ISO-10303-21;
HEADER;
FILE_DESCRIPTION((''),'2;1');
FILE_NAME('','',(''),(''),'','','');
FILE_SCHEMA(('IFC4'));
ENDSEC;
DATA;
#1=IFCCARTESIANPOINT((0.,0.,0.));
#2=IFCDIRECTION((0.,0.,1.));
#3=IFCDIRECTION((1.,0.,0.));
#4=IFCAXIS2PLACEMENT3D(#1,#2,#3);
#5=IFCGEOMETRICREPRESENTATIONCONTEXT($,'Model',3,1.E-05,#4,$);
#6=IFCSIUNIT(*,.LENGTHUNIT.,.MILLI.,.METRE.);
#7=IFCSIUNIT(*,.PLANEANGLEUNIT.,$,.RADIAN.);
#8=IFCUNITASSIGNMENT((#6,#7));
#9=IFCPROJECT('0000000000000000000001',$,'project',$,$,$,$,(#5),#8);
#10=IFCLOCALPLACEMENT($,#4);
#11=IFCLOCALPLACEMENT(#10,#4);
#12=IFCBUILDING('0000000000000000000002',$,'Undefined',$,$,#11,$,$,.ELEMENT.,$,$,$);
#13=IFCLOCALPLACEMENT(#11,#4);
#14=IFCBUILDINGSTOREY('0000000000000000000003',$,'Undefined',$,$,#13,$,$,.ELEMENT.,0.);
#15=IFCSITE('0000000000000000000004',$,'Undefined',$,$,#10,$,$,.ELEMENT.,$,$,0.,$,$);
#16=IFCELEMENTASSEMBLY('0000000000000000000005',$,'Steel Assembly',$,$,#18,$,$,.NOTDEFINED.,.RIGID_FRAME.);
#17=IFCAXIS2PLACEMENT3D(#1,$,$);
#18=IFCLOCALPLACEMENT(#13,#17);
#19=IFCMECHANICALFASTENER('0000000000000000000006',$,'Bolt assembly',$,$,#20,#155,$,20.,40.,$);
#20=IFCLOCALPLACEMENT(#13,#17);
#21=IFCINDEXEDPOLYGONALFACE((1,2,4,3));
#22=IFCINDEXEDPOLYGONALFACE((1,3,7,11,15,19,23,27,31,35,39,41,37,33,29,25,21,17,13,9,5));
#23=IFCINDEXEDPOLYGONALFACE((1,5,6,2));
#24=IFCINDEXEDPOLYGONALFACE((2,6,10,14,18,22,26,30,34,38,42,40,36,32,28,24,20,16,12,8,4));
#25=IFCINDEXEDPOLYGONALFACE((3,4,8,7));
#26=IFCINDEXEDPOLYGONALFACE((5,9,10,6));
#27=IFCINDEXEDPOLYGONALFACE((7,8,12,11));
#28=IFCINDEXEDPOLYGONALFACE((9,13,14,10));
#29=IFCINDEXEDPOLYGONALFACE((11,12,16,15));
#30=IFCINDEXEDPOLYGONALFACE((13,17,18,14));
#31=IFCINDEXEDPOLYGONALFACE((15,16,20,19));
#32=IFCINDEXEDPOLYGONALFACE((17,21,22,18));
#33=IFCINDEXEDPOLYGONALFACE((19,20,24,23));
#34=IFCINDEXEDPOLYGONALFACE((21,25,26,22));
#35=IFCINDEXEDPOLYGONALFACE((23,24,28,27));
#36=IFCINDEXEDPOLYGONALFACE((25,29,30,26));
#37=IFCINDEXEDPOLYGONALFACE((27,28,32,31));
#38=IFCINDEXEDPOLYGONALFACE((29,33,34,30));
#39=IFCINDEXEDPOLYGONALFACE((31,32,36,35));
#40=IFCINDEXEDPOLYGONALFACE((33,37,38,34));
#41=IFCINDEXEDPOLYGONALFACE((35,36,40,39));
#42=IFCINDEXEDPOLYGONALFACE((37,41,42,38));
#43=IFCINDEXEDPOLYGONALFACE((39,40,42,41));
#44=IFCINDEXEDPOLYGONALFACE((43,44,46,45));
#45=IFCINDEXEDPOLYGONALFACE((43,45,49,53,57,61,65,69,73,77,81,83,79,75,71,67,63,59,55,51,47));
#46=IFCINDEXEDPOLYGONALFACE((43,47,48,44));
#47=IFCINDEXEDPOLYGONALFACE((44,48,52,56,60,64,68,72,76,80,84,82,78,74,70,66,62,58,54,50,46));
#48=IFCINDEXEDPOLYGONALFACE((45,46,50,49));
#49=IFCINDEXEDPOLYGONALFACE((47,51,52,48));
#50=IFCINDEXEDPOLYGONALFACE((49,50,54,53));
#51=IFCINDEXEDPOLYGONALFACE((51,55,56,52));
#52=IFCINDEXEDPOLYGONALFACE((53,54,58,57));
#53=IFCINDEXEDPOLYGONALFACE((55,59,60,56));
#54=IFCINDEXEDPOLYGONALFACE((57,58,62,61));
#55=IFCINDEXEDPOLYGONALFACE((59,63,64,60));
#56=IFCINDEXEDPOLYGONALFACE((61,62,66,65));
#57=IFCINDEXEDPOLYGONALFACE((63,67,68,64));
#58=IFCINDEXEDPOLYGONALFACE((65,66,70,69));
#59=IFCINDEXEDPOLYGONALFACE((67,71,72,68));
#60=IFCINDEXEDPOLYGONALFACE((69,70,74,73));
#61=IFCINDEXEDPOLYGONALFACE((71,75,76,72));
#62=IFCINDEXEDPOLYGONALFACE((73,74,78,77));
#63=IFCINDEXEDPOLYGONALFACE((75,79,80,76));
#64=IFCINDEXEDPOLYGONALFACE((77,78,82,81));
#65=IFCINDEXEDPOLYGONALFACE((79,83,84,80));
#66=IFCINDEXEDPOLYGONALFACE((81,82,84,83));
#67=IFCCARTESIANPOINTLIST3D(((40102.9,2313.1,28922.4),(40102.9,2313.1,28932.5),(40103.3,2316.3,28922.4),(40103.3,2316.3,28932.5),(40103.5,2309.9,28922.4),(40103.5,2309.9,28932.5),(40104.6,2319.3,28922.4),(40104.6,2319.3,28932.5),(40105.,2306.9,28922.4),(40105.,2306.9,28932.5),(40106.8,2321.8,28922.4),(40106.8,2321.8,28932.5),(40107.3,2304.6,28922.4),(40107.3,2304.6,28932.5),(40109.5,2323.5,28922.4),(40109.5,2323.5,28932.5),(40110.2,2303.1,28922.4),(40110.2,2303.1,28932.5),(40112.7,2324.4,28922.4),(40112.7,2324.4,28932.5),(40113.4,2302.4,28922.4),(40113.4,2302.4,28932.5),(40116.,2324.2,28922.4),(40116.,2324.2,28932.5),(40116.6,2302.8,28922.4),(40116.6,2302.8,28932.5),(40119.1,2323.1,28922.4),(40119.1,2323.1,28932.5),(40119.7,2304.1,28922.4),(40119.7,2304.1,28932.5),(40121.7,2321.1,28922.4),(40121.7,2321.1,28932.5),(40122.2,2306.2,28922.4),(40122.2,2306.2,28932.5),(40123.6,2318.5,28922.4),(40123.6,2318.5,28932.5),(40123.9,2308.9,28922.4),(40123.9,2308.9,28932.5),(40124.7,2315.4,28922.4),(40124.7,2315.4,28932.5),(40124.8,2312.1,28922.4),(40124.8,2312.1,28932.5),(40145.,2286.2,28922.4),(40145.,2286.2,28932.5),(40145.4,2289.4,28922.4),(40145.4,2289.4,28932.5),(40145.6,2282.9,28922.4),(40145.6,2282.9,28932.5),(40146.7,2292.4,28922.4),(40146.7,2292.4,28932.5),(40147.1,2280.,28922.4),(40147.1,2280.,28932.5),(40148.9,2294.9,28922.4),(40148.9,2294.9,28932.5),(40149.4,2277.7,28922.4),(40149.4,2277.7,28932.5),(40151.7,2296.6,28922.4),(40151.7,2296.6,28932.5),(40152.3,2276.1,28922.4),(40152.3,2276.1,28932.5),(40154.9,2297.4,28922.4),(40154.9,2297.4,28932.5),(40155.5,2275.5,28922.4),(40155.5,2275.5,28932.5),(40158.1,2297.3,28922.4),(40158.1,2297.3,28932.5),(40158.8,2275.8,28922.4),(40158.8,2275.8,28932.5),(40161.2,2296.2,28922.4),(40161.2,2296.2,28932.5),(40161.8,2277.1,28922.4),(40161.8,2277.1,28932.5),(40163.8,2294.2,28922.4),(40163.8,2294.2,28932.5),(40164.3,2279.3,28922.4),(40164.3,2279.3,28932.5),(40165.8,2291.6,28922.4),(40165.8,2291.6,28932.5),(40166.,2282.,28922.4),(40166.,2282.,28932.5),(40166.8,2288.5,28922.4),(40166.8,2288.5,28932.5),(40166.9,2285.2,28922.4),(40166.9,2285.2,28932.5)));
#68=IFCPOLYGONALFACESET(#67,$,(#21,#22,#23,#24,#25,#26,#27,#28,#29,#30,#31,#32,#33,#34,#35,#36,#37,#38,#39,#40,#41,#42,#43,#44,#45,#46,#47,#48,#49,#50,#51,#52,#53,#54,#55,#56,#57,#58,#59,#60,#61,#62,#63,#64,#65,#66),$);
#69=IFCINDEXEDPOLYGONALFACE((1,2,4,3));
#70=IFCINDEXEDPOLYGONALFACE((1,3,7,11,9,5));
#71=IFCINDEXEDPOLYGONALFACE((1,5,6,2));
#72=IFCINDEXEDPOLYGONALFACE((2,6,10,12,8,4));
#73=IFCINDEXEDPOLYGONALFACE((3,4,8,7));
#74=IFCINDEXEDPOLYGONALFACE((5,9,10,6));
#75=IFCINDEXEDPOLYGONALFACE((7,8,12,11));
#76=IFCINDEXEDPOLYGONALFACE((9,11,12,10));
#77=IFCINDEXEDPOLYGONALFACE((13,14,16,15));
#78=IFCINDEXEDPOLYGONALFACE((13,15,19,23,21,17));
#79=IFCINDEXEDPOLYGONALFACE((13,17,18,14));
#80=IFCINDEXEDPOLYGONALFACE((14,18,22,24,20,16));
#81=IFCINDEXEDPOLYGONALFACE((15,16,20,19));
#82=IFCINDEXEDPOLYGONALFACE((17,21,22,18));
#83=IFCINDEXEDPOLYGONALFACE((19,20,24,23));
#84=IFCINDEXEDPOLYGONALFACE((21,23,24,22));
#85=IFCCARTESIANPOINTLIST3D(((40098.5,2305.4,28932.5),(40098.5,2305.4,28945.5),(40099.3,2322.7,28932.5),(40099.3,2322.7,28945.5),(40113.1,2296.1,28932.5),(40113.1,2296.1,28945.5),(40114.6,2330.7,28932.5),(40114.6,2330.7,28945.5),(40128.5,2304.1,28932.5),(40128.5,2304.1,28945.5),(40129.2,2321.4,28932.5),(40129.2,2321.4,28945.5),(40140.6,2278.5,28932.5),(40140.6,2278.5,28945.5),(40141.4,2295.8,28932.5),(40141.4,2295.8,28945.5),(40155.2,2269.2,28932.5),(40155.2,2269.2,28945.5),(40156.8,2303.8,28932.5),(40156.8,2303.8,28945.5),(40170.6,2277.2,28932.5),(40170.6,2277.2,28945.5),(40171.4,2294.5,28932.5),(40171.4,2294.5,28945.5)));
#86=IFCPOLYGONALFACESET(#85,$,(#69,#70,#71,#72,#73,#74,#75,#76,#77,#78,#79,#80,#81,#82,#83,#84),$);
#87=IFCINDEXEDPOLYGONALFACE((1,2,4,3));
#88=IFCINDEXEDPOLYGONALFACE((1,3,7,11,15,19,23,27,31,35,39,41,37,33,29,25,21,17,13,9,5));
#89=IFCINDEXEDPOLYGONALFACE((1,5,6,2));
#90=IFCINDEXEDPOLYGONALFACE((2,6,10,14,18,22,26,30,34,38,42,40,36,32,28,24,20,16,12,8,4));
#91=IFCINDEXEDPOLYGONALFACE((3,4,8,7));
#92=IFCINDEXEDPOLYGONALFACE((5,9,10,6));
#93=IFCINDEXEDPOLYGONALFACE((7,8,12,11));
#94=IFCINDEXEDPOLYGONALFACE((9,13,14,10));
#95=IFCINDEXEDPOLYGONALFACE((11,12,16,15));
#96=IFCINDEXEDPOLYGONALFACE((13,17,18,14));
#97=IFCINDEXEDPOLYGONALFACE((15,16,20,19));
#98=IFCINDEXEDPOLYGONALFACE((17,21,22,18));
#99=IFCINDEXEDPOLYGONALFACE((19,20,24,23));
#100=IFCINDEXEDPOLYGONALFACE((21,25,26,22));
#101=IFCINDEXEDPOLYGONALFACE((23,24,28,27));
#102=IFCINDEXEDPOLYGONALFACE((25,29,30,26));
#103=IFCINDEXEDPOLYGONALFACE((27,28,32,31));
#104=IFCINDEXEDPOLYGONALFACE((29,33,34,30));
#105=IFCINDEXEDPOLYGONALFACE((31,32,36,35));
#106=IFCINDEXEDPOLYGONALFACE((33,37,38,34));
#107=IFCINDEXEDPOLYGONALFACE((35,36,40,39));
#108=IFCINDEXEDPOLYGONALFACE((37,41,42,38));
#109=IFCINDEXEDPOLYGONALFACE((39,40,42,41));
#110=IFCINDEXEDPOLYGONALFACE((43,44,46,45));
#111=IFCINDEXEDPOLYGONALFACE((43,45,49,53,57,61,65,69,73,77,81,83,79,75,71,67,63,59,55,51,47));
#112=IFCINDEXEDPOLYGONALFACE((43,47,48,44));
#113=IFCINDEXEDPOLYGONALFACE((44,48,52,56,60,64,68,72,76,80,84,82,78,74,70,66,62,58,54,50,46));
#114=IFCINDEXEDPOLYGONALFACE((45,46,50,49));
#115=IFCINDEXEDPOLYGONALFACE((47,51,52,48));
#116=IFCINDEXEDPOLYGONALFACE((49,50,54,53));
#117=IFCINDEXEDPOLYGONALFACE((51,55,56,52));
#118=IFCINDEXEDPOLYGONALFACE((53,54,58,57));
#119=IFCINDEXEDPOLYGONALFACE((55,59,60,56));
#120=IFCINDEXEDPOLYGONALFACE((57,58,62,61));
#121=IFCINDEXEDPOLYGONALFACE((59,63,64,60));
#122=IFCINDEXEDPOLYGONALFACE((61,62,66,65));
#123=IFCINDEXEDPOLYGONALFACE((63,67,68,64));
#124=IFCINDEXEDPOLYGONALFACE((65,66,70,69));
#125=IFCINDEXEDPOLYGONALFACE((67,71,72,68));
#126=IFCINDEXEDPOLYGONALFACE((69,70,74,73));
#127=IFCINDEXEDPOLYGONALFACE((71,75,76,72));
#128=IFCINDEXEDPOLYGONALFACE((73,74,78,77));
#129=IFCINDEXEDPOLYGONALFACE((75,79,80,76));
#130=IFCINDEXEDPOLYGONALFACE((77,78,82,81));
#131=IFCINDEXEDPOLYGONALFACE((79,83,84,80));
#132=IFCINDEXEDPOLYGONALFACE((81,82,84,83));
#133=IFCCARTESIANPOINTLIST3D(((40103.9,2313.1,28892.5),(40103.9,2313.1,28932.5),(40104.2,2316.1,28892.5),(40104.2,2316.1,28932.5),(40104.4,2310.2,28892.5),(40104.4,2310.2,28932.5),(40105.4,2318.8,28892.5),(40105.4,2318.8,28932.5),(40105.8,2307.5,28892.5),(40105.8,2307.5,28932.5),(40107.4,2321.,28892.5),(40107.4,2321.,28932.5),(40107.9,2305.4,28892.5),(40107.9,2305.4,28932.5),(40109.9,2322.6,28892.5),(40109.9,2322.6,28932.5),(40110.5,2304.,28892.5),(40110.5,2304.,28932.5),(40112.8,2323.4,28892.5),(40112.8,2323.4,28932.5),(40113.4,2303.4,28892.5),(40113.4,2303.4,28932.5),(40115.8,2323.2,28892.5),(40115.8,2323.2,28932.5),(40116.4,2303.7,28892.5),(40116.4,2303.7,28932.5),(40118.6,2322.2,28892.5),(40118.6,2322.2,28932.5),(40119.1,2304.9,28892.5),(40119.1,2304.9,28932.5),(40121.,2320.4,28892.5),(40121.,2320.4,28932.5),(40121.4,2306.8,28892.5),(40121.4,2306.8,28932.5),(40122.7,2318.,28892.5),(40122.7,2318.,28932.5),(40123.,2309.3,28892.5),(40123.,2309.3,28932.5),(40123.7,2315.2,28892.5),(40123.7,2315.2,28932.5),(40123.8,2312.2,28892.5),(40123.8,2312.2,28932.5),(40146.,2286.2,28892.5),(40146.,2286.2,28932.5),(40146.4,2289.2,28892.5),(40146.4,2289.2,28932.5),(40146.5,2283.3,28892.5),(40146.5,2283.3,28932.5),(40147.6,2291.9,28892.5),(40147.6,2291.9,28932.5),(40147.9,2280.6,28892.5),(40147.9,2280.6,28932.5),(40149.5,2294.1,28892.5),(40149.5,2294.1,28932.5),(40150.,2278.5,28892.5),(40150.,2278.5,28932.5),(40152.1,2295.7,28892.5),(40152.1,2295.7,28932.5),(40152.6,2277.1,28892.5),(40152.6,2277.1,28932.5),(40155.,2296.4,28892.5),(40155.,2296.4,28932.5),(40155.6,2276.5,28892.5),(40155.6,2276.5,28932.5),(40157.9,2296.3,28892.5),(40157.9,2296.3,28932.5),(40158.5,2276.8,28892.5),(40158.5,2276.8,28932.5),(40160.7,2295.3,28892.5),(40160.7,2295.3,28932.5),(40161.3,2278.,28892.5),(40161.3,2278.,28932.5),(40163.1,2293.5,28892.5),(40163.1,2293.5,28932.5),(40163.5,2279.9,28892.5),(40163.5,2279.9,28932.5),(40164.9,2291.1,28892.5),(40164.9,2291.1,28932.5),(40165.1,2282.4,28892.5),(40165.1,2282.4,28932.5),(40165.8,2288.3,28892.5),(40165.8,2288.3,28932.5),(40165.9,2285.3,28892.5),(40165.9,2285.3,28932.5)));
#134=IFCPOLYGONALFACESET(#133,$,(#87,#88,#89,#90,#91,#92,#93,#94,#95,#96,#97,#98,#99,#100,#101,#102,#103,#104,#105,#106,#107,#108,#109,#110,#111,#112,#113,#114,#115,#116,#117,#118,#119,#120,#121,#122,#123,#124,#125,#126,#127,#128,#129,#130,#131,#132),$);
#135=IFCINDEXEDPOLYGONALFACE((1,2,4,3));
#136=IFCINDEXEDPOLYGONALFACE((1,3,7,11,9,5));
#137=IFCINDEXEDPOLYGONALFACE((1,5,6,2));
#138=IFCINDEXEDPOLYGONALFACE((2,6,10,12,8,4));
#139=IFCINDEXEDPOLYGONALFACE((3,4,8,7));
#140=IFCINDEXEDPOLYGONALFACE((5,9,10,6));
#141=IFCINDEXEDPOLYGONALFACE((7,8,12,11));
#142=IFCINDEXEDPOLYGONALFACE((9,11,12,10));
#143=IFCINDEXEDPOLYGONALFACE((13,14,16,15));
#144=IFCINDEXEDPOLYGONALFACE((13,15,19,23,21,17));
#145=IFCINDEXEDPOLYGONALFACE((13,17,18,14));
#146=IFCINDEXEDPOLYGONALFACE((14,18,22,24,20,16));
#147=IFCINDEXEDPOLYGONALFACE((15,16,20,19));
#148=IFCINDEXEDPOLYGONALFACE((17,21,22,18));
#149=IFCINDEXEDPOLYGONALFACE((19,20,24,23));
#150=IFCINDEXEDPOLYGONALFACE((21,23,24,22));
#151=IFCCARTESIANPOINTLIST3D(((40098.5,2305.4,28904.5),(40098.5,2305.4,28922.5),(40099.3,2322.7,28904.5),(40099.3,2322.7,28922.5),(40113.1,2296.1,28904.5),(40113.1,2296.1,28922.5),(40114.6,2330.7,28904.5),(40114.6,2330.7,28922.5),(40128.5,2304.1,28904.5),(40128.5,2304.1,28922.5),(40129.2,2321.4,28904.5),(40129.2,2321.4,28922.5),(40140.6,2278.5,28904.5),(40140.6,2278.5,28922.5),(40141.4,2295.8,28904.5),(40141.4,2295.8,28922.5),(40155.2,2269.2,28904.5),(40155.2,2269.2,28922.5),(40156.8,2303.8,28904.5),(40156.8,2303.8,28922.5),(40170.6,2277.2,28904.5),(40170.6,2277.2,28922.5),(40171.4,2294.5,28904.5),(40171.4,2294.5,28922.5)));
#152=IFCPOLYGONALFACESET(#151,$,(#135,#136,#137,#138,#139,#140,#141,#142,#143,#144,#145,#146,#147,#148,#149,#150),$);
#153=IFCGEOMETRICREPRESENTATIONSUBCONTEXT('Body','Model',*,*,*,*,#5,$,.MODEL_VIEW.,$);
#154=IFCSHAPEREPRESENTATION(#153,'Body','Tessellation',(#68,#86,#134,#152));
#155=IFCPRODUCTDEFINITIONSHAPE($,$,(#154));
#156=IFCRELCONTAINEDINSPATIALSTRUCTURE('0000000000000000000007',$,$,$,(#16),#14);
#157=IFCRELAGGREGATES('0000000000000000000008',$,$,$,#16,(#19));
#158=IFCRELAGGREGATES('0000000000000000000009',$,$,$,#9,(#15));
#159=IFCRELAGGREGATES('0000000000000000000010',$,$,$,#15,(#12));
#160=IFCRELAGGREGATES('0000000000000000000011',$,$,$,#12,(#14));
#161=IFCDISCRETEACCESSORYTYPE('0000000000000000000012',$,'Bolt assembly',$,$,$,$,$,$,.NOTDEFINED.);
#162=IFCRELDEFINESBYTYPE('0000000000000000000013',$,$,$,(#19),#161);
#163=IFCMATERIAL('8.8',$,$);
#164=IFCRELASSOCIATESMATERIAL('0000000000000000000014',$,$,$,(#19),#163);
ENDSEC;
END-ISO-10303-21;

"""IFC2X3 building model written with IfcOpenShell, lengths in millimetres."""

from ifc_helpers import new_model, si_unit, frame, origin_with_axes, origin_2d_with_axis, place, context, subcontext, project, spatial, polyline, circle, outline, extrude, source, transform, mapped, material, type_object, element, aggregate, save


model = new_model("IFC2X3")

# Units and contexts
model_context = context("Model", 3, precision=1e-05, world=origin_with_axes())
body_context = subcontext(model_context, "Body", "Model", "MODEL_VIEW")
ifc_project = project(units=[si_unit("LENGTHUNIT", "METRE", prefix="MILLI"), si_unit("PLANEANGLEUNIT", "RADIAN")], contexts=[model_context])

# Site, building, storey
site_placement = place(None, origin_with_axes())
site = spatial("IfcSite", under=ifc_project, at=site_placement, Name="Undefined", CompositionType="ELEMENT", RefElevation=0.0)
building_placement = place(site_placement, origin_with_axes())
building = spatial("IfcBuilding", under=site, at=building_placement, Name="Undefined", CompositionType="ELEMENT")
storey_placement = place(building_placement, origin_with_axes())
storey = spatial("IfcBuildingStorey", under=building, at=storey_placement, Name="Undefined", CompositionType="ELEMENT", Elevation=0.0)

# Shared definitions
discrete_accessory_type_1 = type_object("IfcDiscreteAccessoryType", Name="Bolt assembly")

# Shared definitions
ifc_material_1 = material(Name="8.8")

# Shared definitions
shared_shape_1 = source(origin_with_axes(), body_context, "Body", "SweptSolid", [
    extrude(circle(Radius=11.0, at=origin_2d_with_axis()), frame((0.0, -10.0, 0.0), z_axis=(0.0, 1.0, 0.0), x_axis=(1.0, 0.0, 0.0)), (0.0, 0.0, 1.0), 10.1),
    extrude(outline(polyline([(17.3, 0.0), (8.7, 15.0), (-8.7, 15.0), (-17.3, 0.0), (-8.7, -15.0), (8.7, -15.0), (17.3, 0.0)])), frame((0.0, -23.0, 0.0), z_axis=(0.0, 1.0, 0.0), x_axis=(1.0, 0.0, 0.0)), (0.0, 0.0, 1.0), 13.0),
    extrude(circle(Radius=10.0, at=origin_2d_with_axis()), frame((0.0, -10.0, 0.0), z_axis=(0.0, 1.0, 0.0), x_axis=(1.0, 0.0, 0.0)), (0.0, 0.0, 1.0), 40.0),
    extrude(outline(polyline([(17.3, 0.0), (8.7, 15.0), (-8.7, 15.0), (-17.3, 0.0), (-8.7, -15.0), (8.7, -15.0), (17.3, 0.0)])), frame((0.0, 0.0, 0.0), z_axis=(0.0, 1.0, 0.0), x_axis=(1.0, 0.0, 0.0)), (0.0, 0.0, 1.0), 18.0),
])

# Element assembly, mechanical fastener
assembly_1_placement = place(storey_placement, origin_with_axes())
assembly_1 = element("IfcElementAssembly", 1, at=assembly_1_placement, inside=storey, Name="Steel Assembly", AssemblyPlace="NOTDEFINED", PredefinedType="RIGID_FRAME")
mechanical_fastener_1_placement = place(assembly_1_placement, frame((40156.0, 2286.5, 28922.5), z_axis=(-0.538475, -0.842642, 0.0), x_axis=(-0.842642, 0.538475, 0.0)))
mechanical_fastener_1 = element("IfcMechanicalFastener", 2, at=mechanical_fastener_1_placement, type_object=discrete_accessory_type_1, material=ifc_material_1, Name="Bolt assembly", NominalDiameter=20.0, NominalLength=40.0, context=body_context, shape_type="MappedRepresentation", body=[
    mapped(shared_shape_1, transform((0.0, 0.0, 0.0))),
    mapped(shared_shape_1, transform((50.0, 0.0, 0.0))),
])
aggregate(assembly_1, [mechanical_fastener_1])

save(model, "model.ifc")
